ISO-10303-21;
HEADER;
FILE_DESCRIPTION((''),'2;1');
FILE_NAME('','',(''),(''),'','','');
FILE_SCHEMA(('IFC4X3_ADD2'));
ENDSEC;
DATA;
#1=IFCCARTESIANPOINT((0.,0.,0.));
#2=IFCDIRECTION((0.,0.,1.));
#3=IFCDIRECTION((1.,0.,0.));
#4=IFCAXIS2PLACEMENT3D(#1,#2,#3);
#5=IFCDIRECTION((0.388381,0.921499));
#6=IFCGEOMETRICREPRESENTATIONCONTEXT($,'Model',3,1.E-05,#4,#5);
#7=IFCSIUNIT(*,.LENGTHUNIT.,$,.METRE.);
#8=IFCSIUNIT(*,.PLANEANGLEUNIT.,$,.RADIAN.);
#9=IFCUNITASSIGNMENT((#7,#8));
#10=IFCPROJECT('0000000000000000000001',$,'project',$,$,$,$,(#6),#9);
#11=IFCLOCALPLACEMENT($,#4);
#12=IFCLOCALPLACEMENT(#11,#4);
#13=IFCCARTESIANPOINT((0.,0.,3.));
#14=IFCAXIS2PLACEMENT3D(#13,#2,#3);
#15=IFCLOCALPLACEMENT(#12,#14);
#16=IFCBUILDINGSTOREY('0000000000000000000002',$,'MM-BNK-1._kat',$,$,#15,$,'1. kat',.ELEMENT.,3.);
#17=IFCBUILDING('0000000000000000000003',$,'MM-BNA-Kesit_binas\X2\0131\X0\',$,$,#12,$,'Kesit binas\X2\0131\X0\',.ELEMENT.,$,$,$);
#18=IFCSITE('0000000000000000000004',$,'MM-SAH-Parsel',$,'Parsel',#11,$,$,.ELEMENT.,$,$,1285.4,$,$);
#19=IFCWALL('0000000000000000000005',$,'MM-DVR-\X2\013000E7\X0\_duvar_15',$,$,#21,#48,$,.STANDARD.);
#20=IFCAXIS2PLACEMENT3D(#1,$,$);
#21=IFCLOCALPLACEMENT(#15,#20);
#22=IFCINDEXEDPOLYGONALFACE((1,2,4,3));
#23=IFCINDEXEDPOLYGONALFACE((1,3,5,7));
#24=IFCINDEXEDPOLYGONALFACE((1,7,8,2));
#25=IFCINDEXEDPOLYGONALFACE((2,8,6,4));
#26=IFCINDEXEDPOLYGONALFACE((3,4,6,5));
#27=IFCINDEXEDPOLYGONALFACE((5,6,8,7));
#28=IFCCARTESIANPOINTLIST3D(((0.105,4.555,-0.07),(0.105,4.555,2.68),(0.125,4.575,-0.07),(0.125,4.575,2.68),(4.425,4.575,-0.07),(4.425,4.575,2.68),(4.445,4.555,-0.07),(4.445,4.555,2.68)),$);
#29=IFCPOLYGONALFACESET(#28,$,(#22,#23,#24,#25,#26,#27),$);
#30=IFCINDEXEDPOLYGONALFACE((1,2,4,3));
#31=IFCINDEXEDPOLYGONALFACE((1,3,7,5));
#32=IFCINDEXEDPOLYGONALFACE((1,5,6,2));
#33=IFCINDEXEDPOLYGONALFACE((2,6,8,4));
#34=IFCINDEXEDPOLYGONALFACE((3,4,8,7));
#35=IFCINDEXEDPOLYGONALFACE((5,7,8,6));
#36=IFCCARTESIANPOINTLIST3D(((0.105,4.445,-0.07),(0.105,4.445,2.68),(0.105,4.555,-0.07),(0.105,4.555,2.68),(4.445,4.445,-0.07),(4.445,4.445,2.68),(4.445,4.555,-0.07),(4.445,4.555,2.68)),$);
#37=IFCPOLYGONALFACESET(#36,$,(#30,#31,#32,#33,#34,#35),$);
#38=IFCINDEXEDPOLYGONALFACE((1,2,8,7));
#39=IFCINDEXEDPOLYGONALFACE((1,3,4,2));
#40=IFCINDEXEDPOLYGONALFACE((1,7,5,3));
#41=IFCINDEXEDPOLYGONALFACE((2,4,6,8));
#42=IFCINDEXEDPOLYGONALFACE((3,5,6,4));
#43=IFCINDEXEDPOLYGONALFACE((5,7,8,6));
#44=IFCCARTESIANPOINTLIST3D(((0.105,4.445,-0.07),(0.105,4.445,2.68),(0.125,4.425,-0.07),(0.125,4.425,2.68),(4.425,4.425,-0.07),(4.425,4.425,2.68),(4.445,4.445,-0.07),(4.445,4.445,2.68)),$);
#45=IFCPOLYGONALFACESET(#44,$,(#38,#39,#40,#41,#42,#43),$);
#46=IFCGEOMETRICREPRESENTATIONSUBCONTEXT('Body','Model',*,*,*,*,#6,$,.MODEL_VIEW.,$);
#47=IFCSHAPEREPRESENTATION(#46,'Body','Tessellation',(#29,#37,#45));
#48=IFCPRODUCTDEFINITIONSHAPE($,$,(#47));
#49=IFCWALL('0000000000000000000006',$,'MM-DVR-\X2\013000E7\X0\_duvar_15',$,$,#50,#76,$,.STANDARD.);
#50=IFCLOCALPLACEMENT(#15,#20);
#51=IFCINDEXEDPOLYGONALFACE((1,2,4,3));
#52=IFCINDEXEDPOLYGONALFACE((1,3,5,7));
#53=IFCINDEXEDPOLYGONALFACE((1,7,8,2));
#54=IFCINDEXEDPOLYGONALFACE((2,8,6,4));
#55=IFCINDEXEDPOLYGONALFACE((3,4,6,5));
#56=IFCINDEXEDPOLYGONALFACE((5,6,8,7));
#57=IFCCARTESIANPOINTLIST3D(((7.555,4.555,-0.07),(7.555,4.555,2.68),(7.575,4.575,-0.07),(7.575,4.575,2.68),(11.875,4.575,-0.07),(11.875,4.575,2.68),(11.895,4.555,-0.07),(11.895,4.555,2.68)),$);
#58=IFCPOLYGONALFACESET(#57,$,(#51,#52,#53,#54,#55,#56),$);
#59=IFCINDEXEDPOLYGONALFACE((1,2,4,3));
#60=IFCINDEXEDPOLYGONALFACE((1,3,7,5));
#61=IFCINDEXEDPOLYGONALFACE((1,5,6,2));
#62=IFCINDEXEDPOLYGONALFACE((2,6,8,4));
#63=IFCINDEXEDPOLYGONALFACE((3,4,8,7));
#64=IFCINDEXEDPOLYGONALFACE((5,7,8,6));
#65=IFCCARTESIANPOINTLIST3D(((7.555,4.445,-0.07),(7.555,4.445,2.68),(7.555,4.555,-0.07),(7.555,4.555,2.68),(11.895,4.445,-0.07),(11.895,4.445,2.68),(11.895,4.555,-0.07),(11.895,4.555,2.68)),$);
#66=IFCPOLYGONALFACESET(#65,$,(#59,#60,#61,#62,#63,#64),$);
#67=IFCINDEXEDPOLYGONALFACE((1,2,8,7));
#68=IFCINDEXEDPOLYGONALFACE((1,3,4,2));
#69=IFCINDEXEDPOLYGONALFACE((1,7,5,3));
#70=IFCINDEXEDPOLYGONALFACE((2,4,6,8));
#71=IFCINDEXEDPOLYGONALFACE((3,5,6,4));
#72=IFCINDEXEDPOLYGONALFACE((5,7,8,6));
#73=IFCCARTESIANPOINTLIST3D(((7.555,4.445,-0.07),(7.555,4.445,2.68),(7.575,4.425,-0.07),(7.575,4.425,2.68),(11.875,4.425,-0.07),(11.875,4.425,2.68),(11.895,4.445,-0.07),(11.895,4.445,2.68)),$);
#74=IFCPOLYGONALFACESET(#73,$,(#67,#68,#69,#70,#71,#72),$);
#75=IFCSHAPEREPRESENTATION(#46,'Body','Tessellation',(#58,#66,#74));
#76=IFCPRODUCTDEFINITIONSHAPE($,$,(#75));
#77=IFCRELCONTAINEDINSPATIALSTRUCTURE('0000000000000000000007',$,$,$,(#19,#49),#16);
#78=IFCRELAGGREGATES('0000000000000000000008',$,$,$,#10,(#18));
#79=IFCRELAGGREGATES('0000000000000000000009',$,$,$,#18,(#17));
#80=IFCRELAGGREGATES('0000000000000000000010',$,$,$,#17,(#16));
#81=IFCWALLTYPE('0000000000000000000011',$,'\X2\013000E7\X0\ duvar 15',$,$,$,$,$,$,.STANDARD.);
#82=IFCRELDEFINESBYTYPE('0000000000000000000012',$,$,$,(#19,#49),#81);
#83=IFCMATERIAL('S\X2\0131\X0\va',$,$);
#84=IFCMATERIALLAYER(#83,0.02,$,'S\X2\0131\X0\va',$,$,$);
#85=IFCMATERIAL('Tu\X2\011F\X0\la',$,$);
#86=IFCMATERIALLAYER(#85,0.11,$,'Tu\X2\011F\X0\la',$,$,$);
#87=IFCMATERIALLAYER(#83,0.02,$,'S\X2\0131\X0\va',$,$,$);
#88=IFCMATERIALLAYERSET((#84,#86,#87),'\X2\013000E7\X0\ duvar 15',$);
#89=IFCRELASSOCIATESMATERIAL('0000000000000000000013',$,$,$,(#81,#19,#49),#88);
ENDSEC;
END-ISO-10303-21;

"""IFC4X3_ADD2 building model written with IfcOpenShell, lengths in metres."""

from ifc_helpers import new_model, si_unit, direction, frame, origin_with_axes, place, context, subcontext, project, spatial, polyline, outline, extrude, material, layer, layer_set, type_object, element, save


model = new_model("IFC4X3_ADD2")

# Units and contexts
model_context = context("Model", 3, precision=1e-05, world=origin_with_axes(), true_north=direction((0.388381, 0.921499)))
body_context = subcontext(model_context, "Body", "Model", "MODEL_VIEW")
ifc_project = project(units=[si_unit("LENGTHUNIT", "METRE"), si_unit("PLANEANGLEUNIT", "RADIAN")], contexts=[model_context])

# Site, building, storey
site_placement = place(None, origin_with_axes())
site = spatial("IfcSite", under=ifc_project, at=site_placement, Name="MM-SAH-Parsel", ObjectType="Parsel", CompositionType="ELEMENT", RefElevation=1285.4)
building_placement = place(site_placement, origin_with_axes())
building = spatial("IfcBuilding", under=site, at=building_placement, Name="MM-BNA-Kesit_binası", LongName="Kesit binası", CompositionType="ELEMENT")
storey_placement = place(building_placement, frame((0.0, 0.0, 3.0), z_axis=(0.0, 0.0, 1.0), x_axis=(1.0, 0.0, 0.0)))
storey = spatial("IfcBuildingStorey", under=building, at=storey_placement, Name="MM-BNK-1._kat", LongName="1. kat", CompositionType="ELEMENT", Elevation=3.0)

# Shared definitions
ifc_material_1 = material(Name="Tuğla")

# Shared definitions
ifc_material_2 = material(Name="Sıva")
ifc_layer_1 = layer(ifc_material_2, 0.02, Name="Sıva")
ifc_layer_2 = layer(ifc_material_1, 0.11, Name="Tuğla")
ifc_layer_3 = layer(ifc_material_2, 0.02, Name="Sıva")
ifc_layer_set_1 = layer_set([ifc_layer_1, ifc_layer_2, ifc_layer_3], Name="İç duvar 15")
wall_type_1 = type_object("IfcWallType", Name="İç duvar 15", PredefinedType="STANDARD", material=ifc_layer_set_1)

# Walls
wall_1_placement = place(storey_placement, origin_with_axes())
element("IfcWall", 1, at=wall_1_placement, inside=storey, type_object=wall_type_1, material=ifc_layer_set_1, Name="MM-DVR-İç_duvar_15", PredefinedType="STANDARD", context=body_context, shape_type="SweptSolid", body=[
    extrude(outline(polyline([(0.125, 4.575), (4.425, 4.575), (4.445, 4.555), (0.105, 4.555), (0.125, 4.575)])), frame((0.0, 0.0, -0.07)), (0.0, 0.0, 1.0), 2.75),
    extrude(outline(polyline([(0.105, 4.555), (4.445, 4.555), (4.445, 4.445), (0.105, 4.445), (0.105, 4.555)])), frame((0.0, 0.0, -0.07)), (0.0, 0.0, 1.0), 2.75),
    extrude(outline(polyline([(0.105, 4.445), (4.445, 4.445), (4.425, 4.425), (0.125, 4.425), (0.105, 4.445)])), frame((0.0, 0.0, -0.07)), (0.0, 0.0, 1.0), 2.75),
])
wall_2_placement = place(storey_placement, origin_with_axes())
element("IfcWall", 2, at=wall_2_placement, inside=storey, type_object=wall_type_1, material=ifc_layer_set_1, Name="MM-DVR-İç_duvar_15", PredefinedType="STANDARD", context=body_context, shape_type="SweptSolid", body=[
    extrude(outline(polyline([(7.575, 4.575), (11.875, 4.575), (11.895, 4.555), (7.555, 4.555), (7.575, 4.575)])), frame((0.0, 0.0, -0.07)), (0.0, 0.0, 1.0), 2.75),
    extrude(outline(polyline([(7.555, 4.555), (11.895, 4.555), (11.895, 4.445), (7.555, 4.445), (7.555, 4.555)])), frame((0.0, 0.0, -0.07)), (0.0, 0.0, 1.0), 2.75),
    extrude(outline(polyline([(7.555, 4.445), (11.895, 4.445), (11.875, 4.425), (7.575, 4.425), (7.555, 4.445)])), frame((0.0, 0.0, -0.07)), (0.0, 0.0, 1.0), 2.75),
])

save(model, "model.ifc")
